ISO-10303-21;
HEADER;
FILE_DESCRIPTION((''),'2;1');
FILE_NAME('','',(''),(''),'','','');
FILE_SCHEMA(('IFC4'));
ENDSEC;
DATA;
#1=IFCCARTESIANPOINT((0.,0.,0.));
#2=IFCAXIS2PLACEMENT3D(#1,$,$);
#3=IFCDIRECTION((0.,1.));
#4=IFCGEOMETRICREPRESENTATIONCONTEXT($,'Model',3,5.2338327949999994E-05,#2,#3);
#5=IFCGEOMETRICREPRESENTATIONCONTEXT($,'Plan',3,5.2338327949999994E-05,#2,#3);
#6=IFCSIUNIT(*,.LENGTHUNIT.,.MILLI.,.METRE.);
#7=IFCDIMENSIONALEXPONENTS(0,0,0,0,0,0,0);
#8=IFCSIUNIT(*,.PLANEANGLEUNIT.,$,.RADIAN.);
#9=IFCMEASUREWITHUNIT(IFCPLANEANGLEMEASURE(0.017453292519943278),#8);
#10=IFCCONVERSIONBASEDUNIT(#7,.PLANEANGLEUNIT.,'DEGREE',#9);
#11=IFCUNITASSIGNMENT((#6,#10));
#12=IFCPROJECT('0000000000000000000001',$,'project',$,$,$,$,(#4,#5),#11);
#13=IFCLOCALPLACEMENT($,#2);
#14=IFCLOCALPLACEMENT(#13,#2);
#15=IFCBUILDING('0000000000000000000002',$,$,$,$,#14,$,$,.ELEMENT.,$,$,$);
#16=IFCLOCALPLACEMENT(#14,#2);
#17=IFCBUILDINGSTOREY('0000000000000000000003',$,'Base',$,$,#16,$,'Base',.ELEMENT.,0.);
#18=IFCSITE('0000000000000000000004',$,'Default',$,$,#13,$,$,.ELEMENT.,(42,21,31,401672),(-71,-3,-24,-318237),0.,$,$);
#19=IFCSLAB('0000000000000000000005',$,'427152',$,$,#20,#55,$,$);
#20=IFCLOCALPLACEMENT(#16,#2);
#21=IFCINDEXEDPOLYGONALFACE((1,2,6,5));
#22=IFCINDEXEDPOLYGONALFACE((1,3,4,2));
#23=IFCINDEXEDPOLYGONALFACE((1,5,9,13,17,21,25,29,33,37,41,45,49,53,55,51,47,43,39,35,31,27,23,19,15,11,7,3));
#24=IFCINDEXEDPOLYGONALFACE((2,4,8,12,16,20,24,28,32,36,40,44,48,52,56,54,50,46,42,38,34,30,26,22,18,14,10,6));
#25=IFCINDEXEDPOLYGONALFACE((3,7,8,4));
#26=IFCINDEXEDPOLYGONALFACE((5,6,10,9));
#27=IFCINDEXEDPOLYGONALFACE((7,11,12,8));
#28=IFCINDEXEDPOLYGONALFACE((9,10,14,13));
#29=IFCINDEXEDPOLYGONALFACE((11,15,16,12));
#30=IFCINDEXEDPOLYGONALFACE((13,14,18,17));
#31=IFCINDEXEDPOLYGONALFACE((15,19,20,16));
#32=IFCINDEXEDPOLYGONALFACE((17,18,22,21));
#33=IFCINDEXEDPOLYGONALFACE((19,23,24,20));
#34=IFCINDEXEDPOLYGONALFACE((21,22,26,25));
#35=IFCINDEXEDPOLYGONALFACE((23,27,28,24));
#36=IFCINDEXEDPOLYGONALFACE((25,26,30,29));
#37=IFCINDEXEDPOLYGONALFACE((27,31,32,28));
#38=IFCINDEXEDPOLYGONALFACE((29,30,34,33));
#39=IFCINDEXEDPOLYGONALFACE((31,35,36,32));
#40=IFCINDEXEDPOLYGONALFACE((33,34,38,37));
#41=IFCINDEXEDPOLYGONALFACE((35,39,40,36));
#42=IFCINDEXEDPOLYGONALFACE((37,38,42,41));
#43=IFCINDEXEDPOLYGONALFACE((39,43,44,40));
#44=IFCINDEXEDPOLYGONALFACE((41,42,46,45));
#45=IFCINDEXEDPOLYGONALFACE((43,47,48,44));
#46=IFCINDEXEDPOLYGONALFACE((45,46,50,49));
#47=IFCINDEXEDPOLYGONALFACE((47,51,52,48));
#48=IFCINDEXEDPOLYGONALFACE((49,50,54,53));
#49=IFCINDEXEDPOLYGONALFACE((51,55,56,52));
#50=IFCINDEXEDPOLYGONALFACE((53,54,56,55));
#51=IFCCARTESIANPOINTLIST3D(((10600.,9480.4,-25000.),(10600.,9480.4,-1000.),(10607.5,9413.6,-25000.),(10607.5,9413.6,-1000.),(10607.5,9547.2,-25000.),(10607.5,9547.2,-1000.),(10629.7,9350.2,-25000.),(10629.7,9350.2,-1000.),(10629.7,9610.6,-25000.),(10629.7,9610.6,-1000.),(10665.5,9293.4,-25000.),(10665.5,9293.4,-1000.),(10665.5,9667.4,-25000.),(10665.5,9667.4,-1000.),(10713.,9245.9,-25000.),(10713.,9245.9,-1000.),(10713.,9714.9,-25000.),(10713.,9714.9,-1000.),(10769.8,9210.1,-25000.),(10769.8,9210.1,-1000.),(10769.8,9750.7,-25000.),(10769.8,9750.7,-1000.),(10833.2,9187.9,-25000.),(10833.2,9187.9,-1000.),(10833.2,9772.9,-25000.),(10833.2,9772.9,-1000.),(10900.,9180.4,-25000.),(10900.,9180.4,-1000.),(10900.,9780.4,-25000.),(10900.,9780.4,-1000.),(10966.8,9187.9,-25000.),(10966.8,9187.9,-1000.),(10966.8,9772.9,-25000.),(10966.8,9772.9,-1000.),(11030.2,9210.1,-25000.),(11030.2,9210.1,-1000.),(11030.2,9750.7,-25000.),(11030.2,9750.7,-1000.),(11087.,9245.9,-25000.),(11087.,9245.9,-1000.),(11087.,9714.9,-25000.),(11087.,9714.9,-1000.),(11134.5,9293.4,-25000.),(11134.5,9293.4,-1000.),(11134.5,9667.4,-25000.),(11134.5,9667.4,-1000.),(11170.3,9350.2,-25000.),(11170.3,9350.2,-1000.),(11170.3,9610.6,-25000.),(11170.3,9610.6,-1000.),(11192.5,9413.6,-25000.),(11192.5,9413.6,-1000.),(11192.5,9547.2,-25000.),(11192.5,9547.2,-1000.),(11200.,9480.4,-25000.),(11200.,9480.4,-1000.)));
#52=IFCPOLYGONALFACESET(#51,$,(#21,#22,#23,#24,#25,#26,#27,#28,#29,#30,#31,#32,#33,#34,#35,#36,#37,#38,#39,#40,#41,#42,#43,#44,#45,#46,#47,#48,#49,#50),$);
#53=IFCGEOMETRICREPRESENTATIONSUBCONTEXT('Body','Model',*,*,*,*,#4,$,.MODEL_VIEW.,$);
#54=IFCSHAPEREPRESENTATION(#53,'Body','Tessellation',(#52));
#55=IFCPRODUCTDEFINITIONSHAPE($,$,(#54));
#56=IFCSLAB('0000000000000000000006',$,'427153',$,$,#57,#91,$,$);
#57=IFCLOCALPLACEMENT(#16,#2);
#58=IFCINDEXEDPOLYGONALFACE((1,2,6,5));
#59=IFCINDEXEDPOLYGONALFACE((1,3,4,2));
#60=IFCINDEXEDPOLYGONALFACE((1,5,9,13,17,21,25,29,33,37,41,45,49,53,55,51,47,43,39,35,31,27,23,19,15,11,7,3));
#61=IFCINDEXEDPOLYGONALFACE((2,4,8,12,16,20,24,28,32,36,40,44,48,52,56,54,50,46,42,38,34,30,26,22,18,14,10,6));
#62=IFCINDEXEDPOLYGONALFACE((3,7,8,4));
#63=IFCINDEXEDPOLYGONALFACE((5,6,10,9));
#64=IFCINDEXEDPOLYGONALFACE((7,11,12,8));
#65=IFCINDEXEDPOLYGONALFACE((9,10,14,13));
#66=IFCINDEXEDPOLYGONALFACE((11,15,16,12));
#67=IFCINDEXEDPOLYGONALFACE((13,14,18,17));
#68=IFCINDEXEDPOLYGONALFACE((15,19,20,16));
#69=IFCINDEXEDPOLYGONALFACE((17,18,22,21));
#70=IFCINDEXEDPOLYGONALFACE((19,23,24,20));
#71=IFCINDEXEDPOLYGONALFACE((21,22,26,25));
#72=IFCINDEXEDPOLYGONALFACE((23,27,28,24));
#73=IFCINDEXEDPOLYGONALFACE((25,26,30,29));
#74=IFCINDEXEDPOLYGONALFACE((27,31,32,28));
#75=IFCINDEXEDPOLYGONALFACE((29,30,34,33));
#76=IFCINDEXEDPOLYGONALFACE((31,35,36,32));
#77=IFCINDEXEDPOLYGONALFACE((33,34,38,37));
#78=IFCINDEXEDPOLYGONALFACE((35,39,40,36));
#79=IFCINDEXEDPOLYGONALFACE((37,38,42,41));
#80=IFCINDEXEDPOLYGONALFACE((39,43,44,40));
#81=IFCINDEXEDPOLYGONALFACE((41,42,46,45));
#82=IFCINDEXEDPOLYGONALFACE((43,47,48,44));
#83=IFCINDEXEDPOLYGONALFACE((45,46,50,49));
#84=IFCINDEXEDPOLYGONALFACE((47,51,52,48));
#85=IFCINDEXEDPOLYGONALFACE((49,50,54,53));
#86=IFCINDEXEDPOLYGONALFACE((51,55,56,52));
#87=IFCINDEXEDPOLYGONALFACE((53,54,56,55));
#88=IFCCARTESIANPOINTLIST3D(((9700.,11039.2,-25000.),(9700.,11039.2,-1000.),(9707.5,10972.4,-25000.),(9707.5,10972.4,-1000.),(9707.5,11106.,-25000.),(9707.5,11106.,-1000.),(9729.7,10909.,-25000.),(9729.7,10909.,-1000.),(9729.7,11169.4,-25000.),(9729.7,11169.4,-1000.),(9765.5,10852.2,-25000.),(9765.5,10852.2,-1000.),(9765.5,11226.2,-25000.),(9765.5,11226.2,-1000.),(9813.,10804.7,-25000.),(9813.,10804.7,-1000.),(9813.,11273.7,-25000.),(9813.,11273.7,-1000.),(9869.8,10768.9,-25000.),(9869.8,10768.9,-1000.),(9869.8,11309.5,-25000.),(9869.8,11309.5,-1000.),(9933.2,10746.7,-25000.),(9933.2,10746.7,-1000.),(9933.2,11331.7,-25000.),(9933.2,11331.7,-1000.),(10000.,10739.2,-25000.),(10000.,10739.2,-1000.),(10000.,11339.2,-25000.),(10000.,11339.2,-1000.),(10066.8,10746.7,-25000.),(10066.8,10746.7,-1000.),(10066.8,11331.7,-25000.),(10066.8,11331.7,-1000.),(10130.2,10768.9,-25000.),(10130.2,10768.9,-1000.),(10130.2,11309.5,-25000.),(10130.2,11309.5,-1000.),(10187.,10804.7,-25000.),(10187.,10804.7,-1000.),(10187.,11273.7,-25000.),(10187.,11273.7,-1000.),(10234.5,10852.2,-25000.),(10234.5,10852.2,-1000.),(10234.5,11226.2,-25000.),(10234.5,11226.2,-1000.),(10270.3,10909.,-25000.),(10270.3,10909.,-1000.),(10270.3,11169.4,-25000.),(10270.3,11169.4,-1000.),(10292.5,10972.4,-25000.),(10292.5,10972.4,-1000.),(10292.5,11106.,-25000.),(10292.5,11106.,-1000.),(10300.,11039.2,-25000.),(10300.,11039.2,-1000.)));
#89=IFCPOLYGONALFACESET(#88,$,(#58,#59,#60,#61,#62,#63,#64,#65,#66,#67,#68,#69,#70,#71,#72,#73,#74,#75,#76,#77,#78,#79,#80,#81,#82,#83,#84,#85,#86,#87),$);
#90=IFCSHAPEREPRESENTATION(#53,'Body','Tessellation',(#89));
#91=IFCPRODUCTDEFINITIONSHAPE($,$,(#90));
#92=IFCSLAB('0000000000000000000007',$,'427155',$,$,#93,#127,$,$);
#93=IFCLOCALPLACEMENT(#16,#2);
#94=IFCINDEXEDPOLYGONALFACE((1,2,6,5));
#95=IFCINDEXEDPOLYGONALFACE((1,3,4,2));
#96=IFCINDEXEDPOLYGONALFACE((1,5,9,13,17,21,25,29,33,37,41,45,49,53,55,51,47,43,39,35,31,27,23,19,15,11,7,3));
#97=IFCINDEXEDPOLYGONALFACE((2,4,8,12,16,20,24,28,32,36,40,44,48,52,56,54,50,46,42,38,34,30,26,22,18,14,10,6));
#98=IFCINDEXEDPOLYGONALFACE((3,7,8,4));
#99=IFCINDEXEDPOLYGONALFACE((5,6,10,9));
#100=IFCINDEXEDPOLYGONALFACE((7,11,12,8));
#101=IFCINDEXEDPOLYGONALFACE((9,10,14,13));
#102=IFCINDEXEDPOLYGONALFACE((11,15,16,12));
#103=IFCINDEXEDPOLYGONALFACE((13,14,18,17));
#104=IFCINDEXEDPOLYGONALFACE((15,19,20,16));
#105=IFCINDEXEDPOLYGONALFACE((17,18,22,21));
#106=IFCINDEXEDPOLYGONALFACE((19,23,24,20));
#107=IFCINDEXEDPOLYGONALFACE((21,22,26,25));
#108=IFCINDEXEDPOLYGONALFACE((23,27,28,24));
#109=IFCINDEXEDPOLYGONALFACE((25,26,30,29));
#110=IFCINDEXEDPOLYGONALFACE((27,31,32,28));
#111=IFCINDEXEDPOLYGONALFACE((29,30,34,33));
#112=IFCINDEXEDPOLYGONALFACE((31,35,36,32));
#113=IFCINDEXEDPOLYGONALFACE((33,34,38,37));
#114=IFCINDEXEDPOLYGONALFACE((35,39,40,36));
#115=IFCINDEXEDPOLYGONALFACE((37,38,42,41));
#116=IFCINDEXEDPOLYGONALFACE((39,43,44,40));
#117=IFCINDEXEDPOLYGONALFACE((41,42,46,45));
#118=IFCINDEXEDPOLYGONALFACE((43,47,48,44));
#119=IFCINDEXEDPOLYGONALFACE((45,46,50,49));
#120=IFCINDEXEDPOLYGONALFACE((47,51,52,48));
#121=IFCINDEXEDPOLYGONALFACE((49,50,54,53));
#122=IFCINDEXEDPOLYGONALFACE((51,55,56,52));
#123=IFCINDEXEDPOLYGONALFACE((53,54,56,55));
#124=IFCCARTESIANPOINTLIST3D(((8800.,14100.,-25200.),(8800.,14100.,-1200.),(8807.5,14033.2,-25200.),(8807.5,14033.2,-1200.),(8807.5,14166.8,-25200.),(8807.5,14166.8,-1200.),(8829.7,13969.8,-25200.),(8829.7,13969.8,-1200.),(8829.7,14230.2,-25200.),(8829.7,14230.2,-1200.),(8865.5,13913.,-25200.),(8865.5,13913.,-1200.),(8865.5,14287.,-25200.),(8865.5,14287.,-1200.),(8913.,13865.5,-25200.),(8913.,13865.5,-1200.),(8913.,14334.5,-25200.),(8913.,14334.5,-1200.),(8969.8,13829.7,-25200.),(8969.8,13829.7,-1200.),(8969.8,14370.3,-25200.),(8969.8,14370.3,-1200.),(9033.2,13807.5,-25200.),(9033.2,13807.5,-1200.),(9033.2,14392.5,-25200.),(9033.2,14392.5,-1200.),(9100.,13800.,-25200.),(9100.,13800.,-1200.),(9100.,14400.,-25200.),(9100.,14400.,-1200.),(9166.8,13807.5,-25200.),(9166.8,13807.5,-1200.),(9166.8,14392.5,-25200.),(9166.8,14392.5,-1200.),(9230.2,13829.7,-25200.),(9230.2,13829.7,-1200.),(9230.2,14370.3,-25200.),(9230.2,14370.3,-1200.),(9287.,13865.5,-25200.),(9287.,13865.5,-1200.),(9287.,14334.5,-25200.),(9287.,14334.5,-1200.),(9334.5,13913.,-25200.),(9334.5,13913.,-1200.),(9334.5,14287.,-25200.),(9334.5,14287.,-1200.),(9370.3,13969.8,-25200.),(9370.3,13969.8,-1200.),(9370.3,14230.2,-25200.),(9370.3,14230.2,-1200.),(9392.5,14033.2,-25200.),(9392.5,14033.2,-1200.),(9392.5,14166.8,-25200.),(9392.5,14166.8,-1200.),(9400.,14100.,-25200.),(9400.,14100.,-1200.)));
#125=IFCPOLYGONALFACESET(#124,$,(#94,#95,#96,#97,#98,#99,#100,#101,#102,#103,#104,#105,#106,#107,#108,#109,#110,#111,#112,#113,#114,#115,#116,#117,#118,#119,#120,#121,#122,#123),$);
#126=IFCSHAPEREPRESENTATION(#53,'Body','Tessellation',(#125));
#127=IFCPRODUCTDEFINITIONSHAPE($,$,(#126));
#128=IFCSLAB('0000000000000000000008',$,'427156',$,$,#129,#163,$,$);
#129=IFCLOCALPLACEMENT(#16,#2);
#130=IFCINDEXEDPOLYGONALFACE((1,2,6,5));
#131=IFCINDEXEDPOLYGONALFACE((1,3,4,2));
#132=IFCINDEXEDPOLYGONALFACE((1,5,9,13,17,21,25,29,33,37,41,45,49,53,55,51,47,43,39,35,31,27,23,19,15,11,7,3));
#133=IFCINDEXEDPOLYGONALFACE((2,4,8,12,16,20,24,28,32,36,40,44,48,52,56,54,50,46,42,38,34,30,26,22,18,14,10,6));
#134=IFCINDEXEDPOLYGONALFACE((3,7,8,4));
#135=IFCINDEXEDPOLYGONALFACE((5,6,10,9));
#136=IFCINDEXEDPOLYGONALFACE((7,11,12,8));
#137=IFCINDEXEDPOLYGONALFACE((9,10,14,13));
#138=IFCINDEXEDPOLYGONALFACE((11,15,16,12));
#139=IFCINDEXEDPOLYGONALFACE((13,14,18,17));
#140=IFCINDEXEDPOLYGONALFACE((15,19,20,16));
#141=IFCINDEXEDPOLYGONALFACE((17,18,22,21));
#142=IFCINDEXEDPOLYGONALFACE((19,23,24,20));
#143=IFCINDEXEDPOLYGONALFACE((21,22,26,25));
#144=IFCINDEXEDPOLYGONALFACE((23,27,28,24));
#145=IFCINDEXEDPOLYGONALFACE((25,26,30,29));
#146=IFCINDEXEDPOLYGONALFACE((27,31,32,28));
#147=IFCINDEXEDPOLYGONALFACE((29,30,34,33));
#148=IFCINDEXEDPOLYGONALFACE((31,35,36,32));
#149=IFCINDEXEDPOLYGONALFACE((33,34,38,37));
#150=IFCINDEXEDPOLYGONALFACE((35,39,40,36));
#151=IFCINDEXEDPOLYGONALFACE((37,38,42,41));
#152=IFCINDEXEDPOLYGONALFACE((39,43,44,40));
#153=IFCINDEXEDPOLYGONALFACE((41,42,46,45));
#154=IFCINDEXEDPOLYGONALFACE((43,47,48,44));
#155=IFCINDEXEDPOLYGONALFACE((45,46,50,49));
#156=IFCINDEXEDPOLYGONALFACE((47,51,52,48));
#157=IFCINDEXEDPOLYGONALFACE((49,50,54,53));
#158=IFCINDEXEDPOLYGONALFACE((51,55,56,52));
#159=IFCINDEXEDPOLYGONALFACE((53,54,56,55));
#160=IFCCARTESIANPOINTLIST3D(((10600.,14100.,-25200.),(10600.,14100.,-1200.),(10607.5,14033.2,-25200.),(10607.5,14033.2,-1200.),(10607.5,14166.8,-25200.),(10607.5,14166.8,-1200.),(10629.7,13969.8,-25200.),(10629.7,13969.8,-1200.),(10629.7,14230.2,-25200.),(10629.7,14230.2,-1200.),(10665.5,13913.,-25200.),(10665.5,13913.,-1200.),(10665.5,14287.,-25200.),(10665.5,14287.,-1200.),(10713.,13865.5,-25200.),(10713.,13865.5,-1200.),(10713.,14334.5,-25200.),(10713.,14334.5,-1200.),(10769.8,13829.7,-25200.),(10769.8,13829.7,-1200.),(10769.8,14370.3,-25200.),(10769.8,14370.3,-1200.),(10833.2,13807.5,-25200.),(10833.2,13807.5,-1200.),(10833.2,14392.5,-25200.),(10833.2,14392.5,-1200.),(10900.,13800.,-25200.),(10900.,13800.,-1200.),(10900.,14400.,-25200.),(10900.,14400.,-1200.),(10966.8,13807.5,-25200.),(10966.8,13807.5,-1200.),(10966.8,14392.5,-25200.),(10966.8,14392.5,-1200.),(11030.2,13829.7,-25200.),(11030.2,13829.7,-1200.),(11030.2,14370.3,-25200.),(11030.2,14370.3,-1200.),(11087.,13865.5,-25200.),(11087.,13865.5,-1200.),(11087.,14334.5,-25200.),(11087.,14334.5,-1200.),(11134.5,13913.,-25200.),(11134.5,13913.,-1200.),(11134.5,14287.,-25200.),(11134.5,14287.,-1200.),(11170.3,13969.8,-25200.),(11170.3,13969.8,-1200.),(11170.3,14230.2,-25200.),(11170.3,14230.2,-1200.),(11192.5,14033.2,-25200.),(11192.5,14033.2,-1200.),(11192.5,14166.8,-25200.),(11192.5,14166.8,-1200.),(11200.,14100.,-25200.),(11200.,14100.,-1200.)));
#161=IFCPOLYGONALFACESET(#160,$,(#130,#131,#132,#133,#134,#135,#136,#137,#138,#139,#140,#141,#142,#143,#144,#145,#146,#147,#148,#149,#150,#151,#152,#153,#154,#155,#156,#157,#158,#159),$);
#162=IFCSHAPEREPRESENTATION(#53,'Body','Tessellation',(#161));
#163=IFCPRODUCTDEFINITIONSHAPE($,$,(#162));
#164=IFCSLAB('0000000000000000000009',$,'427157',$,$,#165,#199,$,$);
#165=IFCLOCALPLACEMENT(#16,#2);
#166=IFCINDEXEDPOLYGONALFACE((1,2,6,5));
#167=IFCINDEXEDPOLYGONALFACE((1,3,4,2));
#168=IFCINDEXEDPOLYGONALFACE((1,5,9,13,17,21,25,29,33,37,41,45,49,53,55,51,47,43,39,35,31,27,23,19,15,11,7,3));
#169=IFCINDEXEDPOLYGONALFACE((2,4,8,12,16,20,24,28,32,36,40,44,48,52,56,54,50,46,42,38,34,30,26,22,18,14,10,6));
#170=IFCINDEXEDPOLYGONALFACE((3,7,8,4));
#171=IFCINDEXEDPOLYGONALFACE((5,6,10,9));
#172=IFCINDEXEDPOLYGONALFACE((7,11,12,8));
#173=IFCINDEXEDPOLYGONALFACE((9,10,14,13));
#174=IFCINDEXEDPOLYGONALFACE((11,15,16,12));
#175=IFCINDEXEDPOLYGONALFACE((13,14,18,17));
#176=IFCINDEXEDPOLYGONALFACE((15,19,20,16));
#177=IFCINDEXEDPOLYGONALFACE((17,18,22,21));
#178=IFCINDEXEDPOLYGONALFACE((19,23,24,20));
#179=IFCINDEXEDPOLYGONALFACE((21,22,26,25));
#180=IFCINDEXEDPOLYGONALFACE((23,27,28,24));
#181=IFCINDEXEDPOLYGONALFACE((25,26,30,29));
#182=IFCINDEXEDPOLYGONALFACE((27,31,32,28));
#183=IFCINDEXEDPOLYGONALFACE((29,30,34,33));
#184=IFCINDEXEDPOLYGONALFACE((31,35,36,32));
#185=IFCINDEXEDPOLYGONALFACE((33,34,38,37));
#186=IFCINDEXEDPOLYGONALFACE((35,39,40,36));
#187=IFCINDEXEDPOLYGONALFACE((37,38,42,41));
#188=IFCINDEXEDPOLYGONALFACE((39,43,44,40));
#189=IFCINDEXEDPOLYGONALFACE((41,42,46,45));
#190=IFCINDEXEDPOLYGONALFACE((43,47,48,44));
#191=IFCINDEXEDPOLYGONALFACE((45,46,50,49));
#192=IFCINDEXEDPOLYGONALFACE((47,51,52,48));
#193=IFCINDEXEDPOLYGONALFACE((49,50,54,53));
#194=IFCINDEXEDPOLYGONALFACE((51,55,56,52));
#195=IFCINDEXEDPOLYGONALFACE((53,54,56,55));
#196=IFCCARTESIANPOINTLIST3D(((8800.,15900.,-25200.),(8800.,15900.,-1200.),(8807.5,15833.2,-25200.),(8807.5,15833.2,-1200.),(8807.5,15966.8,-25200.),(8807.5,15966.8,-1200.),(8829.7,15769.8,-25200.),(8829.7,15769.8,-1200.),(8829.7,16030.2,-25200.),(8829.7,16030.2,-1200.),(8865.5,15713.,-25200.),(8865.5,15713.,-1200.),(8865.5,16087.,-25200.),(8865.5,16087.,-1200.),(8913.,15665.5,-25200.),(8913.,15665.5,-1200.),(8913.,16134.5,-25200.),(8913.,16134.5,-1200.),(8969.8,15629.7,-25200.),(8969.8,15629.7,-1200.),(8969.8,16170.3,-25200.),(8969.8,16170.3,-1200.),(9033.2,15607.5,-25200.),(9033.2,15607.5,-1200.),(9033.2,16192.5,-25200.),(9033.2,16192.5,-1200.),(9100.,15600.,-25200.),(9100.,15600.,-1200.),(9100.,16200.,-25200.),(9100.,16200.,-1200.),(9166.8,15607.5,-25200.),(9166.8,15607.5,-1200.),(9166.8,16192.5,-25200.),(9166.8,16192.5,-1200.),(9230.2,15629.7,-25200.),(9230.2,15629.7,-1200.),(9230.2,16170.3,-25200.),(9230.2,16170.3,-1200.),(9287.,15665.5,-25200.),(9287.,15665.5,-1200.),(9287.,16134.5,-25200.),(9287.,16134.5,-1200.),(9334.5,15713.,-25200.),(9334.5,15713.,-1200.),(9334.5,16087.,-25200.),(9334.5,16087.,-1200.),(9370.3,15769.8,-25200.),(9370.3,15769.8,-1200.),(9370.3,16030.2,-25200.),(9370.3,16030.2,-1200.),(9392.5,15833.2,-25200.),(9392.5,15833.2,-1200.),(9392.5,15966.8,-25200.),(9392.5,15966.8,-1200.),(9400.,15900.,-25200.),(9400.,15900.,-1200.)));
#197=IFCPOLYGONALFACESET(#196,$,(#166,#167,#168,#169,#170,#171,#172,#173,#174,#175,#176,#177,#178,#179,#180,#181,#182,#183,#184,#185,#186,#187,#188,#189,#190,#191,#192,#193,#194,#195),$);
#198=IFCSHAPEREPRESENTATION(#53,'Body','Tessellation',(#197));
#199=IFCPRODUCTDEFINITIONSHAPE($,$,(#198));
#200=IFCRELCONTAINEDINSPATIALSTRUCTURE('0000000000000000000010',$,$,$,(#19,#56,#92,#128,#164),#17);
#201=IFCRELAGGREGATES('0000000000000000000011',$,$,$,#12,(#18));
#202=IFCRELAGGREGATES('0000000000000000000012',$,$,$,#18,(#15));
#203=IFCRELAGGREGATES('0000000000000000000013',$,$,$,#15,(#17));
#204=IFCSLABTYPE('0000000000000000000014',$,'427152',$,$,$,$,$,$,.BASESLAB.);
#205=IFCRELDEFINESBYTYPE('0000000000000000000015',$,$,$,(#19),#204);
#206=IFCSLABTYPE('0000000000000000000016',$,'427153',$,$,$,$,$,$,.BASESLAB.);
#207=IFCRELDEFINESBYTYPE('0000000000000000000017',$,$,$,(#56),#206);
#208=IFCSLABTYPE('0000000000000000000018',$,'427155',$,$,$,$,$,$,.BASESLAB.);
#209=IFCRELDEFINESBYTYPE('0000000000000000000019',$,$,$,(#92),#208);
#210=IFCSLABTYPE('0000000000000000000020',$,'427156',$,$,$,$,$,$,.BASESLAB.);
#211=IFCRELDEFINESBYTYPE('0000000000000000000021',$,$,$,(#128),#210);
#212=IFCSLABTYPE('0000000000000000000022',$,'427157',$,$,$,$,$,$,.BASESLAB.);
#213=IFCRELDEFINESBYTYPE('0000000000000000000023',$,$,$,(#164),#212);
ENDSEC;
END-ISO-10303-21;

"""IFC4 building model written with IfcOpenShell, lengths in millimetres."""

from ifc_helpers import new_model, entity, si_unit, converted_unit, direction, frame, origin, place, context, subcontext, project, spatial, arc, indexed_curve, outline, extrude, type_object, element, save


model = new_model("IFC4")

# Units and contexts
model_context = context("Model", 3, precision=5.2338327949999994e-05, world=origin(), true_north=direction((0.0, 1.0)))
plan_context = context("Plan", 3, precision=5.2338327949999994e-05, world=origin(), true_north=direction((0.0, 1.0)))
body_context = subcontext(model_context, "Body", "Model", "MODEL_VIEW")
ifc_project = project(units=[si_unit("LENGTHUNIT", "METRE", prefix="MILLI"), converted_unit("PLANEANGLEUNIT", "DEGREE", entity("IfcPlaneAngleMeasure", 0.017453292519943278), si_unit("PLANEANGLEUNIT", "RADIAN"), dimensions=[0, 0, 0, 0, 0, 0, 0])], contexts=[model_context, plan_context])

# Site, building, storey
site_placement = place(None, origin())
site = spatial("IfcSite", under=ifc_project, at=site_placement, Name="Default", CompositionType="ELEMENT", RefLatitude=(42, 21, 31, 401672), RefLongitude=(-71, -3, -24, -318237), RefElevation=0.0)
building_placement = place(site_placement, origin())
building = spatial("IfcBuilding", under=site, at=building_placement, CompositionType="ELEMENT")
storey_placement = place(building_placement, origin())
storey = spatial("IfcBuildingStorey", under=building, at=storey_placement, Name="Base", LongName="Base", CompositionType="ELEMENT", Elevation=0.0)

# Slabs
slab_type_1 = type_object("IfcSlabType", Name="427152", PredefinedType="BASESLAB")
slab_1_placement = place(storey_placement, origin())
element("IfcSlab", 1, at=slab_1_placement, inside=storey, type_object=slab_type_1, Name="427152", context=body_context, shape_type="SweptSolid", body=[
    extrude(outline(indexed_curve([(300.0, 0.0), (0.0, 300.0), (-300.0, 0.0), (0.0, -300.0)], segments=[arc(1, 2, 3), arc(3, 4, 1)], self_intersect=False)), frame((10900.0, 9480.4, -25000.0)), (0.0, 0.0, 1.0), 24000.0),
])
slab_type_2 = type_object("IfcSlabType", Name="427153", PredefinedType="BASESLAB")
slab_2_placement = place(storey_placement, origin())
element("IfcSlab", 2, at=slab_2_placement, inside=storey, type_object=slab_type_2, Name="427153", context=body_context, shape_type="SweptSolid", body=[
    extrude(outline(indexed_curve([(300.0, 0.0), (0.0, 300.0), (-300.0, 0.0), (0.0, -300.0)], segments=[arc(1, 2, 3), arc(3, 4, 1)], self_intersect=False)), frame((10000.0, 11039.2, -25000.0)), (0.0, 0.0, 1.0), 24000.0),
])
slab_type_3 = type_object("IfcSlabType", Name="427155", PredefinedType="BASESLAB")
slab_3_placement = place(storey_placement, origin())
element("IfcSlab", 3, at=slab_3_placement, inside=storey, type_object=slab_type_3, Name="427155", context=body_context, shape_type="SweptSolid", body=[
    extrude(outline(indexed_curve([(300.0, 0.0), (0.0, 300.0), (-300.0, 0.0), (0.0, -300.0)], segments=[arc(1, 2, 3), arc(3, 4, 1)], self_intersect=False)), frame((9100.0, 14100.0, -25200.0)), (0.0, 0.0, 1.0), 24000.0),
])
slab_type_4 = type_object("IfcSlabType", Name="427156", PredefinedType="BASESLAB")
slab_4_placement = place(storey_placement, origin())
element("IfcSlab", 4, at=slab_4_placement, inside=storey, type_object=slab_type_4, Name="427156", context=body_context, shape_type="SweptSolid", body=[
    extrude(outline(indexed_curve([(300.0, 0.0), (0.0, 300.0), (-300.0, 0.0), (0.0, -300.0)], segments=[arc(1, 2, 3), arc(3, 4, 1)], self_intersect=False)), frame((10900.0, 14100.0, -25200.0)), (0.0, 0.0, 1.0), 24000.0),
])
slab_type_5 = type_object("IfcSlabType", Name="427157", PredefinedType="BASESLAB")
slab_5_placement = place(storey_placement, origin())
element("IfcSlab", 5, at=slab_5_placement, inside=storey, type_object=slab_type_5, Name="427157", context=body_context, shape_type="SweptSolid", body=[
    extrude(outline(indexed_curve([(300.0, 0.0), (0.0, 300.0), (-300.0, 0.0), (0.0, -300.0)], segments=[arc(1, 2, 3), arc(3, 4, 1)], self_intersect=False)), frame((9100.0, 15900.0, -25200.0)), (0.0, 0.0, 1.0), 24000.0),
])

save(model, "model.ifc")
